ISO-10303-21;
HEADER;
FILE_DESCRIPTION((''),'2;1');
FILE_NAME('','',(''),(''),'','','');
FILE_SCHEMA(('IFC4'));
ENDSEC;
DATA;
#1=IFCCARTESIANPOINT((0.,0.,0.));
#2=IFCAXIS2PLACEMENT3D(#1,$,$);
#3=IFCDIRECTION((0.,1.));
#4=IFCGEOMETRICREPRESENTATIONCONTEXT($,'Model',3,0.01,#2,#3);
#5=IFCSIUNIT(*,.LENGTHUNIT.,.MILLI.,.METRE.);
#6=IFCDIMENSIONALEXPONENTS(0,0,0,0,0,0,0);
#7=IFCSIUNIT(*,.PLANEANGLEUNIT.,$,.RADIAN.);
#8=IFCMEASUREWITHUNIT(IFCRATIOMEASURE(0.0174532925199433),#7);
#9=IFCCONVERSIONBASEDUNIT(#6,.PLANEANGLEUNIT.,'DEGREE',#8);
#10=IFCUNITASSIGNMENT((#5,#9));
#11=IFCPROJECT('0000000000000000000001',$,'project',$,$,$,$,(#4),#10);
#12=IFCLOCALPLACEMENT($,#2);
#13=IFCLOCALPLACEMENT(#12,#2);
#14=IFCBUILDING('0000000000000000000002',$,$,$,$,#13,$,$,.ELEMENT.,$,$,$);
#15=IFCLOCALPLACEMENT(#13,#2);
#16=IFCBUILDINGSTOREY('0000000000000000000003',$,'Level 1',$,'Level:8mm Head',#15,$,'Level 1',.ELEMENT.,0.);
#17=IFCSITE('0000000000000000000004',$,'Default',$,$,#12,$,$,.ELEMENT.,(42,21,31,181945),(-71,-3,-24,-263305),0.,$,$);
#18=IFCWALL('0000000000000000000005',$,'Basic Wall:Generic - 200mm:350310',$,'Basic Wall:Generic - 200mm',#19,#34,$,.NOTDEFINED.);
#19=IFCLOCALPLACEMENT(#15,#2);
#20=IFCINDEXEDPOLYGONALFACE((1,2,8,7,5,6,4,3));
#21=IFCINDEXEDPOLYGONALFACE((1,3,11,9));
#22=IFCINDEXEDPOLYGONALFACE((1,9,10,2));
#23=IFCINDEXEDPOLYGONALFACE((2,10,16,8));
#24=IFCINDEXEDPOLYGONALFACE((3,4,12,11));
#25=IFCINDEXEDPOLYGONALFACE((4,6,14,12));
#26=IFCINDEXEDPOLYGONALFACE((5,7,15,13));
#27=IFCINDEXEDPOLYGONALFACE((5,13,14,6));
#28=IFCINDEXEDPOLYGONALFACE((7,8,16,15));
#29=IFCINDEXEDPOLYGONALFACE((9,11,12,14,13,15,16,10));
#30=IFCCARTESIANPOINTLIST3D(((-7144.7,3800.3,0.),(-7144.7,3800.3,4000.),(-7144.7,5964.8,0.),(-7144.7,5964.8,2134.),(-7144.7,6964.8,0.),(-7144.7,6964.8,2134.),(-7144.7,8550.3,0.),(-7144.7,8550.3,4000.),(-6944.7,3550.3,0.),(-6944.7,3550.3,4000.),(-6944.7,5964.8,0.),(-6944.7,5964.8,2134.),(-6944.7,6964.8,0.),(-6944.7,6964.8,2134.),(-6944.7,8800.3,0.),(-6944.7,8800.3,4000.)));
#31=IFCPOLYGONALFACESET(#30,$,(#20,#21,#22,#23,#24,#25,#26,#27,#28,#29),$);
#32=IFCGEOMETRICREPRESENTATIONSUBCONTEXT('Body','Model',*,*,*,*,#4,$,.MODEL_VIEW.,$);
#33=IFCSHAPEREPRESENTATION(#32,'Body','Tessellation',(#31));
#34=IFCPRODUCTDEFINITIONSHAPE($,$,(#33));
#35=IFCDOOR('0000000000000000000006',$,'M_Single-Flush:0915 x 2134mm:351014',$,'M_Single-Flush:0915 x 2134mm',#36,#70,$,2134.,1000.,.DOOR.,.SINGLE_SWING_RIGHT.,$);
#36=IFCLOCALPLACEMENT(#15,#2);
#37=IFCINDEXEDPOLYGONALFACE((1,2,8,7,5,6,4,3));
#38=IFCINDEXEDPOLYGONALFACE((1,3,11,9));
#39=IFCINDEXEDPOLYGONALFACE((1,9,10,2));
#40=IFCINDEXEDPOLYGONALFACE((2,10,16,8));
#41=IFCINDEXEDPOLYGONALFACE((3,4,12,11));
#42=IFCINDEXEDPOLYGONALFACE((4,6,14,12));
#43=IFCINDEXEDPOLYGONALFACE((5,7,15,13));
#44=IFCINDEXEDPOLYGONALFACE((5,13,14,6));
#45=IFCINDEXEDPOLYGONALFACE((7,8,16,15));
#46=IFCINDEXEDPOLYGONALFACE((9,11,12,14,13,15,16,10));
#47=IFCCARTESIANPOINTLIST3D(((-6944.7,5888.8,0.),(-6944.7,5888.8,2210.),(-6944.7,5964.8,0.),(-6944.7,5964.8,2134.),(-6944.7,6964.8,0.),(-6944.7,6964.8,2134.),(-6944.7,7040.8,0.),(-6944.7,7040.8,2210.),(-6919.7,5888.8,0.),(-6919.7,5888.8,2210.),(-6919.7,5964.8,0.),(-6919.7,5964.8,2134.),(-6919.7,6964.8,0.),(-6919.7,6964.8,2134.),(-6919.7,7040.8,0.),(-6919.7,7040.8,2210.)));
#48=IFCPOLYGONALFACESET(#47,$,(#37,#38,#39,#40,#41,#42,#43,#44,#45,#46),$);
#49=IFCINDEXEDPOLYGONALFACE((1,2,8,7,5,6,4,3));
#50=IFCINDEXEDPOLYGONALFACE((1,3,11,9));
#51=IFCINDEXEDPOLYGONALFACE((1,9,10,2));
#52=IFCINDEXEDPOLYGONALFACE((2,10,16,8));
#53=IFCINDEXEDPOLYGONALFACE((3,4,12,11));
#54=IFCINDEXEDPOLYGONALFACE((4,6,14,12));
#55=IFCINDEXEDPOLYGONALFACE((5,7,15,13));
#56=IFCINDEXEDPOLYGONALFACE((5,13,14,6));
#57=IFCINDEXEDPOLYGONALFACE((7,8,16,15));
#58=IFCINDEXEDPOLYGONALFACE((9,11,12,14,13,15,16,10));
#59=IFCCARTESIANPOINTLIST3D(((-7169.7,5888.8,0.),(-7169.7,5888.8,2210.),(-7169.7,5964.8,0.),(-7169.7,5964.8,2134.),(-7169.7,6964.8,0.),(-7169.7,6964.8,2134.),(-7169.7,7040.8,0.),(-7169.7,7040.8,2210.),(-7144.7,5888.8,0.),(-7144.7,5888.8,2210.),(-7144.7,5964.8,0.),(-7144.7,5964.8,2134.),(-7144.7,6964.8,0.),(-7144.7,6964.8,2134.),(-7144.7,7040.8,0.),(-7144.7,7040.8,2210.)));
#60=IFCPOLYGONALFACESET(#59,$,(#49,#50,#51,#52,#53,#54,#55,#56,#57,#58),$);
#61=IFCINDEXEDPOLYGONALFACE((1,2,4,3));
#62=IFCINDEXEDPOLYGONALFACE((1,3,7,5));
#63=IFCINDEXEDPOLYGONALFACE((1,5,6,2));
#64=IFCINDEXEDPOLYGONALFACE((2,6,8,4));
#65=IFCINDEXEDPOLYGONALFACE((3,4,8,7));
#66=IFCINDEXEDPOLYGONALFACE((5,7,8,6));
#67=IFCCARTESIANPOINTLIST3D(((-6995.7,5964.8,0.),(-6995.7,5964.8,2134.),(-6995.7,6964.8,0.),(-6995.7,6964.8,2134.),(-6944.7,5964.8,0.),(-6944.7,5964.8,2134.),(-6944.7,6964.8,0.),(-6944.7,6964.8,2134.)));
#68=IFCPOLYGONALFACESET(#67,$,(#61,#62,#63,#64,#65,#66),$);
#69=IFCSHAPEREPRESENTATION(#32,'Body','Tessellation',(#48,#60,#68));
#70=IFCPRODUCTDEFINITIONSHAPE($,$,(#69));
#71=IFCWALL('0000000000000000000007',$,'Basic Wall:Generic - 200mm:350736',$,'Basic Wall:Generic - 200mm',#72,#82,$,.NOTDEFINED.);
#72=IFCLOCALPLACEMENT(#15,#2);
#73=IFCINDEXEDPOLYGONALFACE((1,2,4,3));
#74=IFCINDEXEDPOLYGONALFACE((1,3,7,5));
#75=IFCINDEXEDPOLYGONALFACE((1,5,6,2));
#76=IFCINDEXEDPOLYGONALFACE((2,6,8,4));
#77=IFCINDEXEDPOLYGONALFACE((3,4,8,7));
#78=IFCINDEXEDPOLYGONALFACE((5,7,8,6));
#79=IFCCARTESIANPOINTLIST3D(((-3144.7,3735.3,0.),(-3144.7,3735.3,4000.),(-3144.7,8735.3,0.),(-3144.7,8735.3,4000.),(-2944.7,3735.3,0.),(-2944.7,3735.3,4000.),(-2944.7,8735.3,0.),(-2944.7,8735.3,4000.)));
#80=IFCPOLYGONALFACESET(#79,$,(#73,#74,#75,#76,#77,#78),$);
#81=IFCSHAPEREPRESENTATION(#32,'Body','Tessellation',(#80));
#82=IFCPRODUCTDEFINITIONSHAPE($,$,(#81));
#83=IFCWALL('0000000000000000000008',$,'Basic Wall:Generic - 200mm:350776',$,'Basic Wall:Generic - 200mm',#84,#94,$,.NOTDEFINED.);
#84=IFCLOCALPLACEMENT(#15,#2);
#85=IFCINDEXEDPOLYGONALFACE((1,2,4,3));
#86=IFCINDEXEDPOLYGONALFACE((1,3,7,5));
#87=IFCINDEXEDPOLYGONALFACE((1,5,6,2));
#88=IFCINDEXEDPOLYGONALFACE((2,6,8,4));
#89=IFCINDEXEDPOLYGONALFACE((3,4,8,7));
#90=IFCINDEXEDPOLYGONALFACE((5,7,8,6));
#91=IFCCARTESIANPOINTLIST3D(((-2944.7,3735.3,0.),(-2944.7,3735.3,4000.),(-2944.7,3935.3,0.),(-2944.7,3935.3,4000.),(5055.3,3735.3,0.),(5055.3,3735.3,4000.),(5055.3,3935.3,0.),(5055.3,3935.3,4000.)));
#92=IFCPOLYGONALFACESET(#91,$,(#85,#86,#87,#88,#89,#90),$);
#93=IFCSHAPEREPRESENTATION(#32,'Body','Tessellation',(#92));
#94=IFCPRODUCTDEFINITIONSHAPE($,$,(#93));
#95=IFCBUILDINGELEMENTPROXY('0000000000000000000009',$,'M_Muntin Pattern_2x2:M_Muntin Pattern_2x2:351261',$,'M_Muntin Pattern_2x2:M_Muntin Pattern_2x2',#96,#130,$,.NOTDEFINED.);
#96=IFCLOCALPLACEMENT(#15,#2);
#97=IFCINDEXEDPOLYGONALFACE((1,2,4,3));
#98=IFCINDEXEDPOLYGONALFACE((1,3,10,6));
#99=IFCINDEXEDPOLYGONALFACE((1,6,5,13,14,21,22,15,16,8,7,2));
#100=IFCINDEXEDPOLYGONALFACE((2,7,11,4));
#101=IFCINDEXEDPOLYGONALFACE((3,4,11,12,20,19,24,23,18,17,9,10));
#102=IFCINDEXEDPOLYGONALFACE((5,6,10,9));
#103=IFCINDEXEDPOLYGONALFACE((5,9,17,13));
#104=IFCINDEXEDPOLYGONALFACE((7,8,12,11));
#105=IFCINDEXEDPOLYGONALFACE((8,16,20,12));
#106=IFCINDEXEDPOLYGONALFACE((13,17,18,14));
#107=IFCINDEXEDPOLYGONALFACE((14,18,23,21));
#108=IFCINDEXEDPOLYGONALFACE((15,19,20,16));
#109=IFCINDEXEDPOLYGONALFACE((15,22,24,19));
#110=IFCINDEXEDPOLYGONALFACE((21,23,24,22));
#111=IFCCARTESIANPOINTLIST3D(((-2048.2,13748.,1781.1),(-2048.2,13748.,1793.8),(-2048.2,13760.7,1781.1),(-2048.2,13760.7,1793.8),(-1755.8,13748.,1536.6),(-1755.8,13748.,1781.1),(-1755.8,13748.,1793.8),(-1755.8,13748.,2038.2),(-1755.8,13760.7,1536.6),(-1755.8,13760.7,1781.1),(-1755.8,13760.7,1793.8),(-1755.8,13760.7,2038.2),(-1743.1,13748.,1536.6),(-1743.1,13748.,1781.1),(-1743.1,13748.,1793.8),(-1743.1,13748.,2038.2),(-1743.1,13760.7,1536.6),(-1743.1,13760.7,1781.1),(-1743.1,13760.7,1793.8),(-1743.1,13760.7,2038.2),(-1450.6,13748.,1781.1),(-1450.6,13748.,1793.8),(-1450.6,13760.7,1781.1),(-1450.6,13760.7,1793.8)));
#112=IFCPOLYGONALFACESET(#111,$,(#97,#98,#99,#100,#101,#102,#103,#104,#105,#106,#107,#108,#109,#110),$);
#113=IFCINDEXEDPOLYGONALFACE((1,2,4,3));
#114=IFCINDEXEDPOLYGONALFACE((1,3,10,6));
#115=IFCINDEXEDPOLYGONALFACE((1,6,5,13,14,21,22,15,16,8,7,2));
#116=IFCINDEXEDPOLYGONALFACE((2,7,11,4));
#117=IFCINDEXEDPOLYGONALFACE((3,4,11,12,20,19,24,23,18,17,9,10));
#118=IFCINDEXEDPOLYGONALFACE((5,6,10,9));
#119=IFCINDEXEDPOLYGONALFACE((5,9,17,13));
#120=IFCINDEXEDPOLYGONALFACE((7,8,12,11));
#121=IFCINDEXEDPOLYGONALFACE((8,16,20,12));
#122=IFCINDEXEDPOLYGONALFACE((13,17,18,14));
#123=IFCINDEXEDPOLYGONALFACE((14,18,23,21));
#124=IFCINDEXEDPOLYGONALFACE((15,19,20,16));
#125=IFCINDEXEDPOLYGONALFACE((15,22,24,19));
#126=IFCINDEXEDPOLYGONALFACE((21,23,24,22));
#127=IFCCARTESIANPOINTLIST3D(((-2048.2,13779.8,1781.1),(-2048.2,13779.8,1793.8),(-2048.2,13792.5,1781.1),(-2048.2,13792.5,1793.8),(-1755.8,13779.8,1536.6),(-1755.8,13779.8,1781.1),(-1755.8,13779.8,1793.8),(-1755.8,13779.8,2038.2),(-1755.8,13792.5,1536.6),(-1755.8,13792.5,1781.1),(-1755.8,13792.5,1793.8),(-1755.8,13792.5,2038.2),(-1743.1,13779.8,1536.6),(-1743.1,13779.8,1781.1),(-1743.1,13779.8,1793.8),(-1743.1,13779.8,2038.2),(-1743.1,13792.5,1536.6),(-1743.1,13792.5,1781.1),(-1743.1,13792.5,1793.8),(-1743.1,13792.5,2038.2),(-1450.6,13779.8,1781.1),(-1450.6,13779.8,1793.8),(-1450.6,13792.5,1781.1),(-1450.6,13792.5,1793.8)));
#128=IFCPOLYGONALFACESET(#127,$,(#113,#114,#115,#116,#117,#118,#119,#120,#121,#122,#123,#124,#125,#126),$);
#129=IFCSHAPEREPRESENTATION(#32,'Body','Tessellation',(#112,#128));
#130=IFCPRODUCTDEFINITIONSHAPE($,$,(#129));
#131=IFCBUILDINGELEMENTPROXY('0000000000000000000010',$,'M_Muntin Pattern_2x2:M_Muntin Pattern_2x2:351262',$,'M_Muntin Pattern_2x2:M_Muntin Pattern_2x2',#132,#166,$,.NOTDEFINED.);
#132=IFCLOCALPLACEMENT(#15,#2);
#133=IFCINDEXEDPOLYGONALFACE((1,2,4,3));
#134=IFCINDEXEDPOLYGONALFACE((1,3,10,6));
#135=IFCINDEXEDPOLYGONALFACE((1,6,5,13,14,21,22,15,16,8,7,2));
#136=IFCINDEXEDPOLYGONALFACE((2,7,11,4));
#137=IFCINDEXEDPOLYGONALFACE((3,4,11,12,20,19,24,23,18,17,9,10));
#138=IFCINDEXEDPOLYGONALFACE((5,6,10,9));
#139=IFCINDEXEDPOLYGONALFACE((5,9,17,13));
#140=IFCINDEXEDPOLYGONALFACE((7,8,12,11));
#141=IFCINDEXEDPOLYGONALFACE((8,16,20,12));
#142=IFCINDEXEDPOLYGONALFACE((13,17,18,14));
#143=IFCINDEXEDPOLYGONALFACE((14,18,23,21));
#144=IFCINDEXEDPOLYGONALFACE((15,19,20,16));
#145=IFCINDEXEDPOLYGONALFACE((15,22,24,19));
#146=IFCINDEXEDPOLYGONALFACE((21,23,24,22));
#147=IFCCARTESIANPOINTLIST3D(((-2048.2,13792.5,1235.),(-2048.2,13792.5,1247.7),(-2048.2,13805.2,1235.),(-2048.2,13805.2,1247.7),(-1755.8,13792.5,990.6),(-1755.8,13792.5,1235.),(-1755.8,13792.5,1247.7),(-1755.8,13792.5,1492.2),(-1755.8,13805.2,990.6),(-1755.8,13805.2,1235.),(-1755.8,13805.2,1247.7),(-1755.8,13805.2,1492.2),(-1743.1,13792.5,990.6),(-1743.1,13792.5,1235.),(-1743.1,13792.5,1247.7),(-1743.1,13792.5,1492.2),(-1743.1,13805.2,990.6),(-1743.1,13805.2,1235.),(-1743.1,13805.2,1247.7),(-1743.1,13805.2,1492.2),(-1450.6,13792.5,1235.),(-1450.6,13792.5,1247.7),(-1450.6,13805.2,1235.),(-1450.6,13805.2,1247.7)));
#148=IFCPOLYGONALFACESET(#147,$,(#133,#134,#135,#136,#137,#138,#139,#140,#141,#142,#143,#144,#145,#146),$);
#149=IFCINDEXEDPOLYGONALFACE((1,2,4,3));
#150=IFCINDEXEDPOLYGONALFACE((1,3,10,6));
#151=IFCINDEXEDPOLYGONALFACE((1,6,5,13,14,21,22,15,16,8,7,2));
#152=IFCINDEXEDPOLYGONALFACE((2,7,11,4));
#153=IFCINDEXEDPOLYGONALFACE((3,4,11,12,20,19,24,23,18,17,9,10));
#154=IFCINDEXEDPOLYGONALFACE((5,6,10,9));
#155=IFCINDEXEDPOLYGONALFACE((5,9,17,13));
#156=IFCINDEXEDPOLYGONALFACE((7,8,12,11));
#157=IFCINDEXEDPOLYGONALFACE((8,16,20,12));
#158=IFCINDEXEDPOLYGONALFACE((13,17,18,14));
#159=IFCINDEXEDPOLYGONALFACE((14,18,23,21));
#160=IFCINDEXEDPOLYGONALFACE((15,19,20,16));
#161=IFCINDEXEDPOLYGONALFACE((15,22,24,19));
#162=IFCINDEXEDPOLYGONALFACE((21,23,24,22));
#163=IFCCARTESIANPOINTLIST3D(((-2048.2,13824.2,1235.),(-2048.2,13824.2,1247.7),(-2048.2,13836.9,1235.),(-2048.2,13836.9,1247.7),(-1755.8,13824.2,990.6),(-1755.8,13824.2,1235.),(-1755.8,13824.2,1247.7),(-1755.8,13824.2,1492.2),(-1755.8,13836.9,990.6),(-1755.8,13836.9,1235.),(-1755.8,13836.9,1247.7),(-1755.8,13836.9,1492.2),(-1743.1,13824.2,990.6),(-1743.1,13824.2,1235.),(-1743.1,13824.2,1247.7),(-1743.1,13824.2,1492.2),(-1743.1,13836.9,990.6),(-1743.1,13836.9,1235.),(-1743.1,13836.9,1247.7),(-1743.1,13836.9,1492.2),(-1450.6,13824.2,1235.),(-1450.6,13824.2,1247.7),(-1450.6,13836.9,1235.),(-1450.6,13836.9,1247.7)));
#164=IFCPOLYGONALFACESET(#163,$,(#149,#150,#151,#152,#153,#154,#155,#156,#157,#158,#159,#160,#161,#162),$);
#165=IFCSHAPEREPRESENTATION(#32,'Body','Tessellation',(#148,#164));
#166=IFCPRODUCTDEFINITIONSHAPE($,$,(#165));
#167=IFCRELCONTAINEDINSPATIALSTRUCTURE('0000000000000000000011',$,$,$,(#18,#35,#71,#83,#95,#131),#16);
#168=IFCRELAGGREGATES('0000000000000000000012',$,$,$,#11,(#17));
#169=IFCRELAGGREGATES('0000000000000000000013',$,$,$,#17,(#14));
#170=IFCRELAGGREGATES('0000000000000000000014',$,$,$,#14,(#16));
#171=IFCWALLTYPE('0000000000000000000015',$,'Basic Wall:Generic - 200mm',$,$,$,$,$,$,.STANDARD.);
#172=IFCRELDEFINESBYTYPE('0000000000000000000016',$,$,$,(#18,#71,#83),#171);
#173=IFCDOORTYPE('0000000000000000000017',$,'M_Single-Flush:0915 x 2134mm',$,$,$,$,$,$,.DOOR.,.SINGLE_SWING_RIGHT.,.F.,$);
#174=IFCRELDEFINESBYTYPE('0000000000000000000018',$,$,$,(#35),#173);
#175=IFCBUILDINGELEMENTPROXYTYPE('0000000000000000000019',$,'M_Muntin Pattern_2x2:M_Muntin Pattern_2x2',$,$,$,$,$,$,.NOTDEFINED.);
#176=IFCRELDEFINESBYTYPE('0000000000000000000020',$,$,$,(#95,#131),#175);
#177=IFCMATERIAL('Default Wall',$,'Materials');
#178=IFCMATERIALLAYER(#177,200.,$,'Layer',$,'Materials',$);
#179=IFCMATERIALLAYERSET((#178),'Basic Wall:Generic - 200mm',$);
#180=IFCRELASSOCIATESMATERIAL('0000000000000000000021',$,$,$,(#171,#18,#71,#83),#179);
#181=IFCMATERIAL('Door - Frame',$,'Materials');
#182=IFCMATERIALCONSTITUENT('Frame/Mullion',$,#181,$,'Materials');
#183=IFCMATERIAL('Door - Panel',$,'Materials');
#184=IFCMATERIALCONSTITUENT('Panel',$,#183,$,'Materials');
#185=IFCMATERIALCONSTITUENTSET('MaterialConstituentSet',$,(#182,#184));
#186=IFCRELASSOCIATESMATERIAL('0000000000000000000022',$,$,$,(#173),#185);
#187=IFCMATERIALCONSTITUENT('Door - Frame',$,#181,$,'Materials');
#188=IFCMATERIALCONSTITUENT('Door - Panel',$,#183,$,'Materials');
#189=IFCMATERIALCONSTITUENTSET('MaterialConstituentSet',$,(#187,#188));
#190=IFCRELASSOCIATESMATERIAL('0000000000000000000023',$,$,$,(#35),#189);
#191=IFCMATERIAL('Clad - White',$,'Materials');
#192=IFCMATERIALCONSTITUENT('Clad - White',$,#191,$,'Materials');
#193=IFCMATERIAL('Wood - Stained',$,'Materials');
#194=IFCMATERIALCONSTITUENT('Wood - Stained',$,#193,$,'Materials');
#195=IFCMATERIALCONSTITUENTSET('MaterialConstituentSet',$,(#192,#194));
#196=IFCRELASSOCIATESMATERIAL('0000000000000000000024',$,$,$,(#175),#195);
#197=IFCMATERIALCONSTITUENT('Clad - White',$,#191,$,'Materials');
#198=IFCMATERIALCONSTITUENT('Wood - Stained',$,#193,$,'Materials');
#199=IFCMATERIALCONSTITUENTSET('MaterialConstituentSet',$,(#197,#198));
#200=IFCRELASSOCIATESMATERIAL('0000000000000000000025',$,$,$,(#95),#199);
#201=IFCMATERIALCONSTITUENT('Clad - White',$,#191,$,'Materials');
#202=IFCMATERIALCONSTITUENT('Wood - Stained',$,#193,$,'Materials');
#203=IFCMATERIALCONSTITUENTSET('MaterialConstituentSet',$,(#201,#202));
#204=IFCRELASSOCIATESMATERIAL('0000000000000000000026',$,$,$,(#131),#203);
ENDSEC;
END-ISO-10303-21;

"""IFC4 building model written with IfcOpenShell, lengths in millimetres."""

from ifc_helpers import new_model, entity, si_unit, converted_unit, direction, frame, frame_2d, origin, place, context, subcontext, project, spatial, polyline, rectangle, outline, extrude, source, transform, mapped, material, layer, layer_set, layer_usage, constituent, constituent_set, type_object, type_shapes, element, fill, save


model = new_model("IFC4")

# Units and contexts
model_context = context("Model", 3, precision=0.01, world=origin(), true_north=direction((0.0, 1.0)))
body_context = subcontext(model_context, "Body", "Model", "MODEL_VIEW")
ifc_project = project(units=[si_unit("LENGTHUNIT", "METRE", prefix="MILLI"), converted_unit("PLANEANGLEUNIT", "DEGREE", entity("IfcRatioMeasure", 0.0174532925199433), si_unit("PLANEANGLEUNIT", "RADIAN"), dimensions=[0, 0, 0, 0, 0, 0, 0])], contexts=[model_context])

# Site, building, storey
site_placement = place(None, origin())
site = spatial("IfcSite", under=ifc_project, at=site_placement, Name="Default", CompositionType="ELEMENT", RefLatitude=(42, 21, 31, 181945), RefLongitude=(-71, -3, -24, -263305), RefElevation=0.0)
building_placement = place(site_placement, origin())
building = spatial("IfcBuilding", under=site, at=building_placement, CompositionType="ELEMENT")
storey_placement = place(building_placement, origin())
storey = spatial("IfcBuildingStorey", under=building, at=storey_placement, Name="Level 1", ObjectType="Level:8mm Head", LongName="Level 1", CompositionType="ELEMENT", Elevation=0.0)

# Shared definitions
ifc_material_1 = material(Name="Default Wall", Category="Materials")
ifc_layer = layer(ifc_material_1, 200.0, Name="Layer", Category="Materials")
ifc_layer_set = layer_set([ifc_layer], Name="Basic Wall:Generic - 200mm")
wall_type = type_object("IfcWallType", Name="Basic Wall:Generic - 200mm", PredefinedType="STANDARD", material=ifc_layer_set)
ifc_material_2 = material(Name="Door - Frame", Category="Materials")
ifc_material_3 = material(Name="Door - Panel", Category="Materials")
ifc_constituent_1 = constituent(ifc_material_2, Name="Frame/Mullion", Category="Materials")
ifc_constituent_2 = constituent(ifc_material_3, Name="Panel", Category="Materials")
ifc_constituent_set_1 = constituent_set(constituents=[ifc_constituent_1, ifc_constituent_2], Name="MaterialConstituentSet")
door_type = type_object("IfcDoorType", Name="M_Single-Flush:0915 x 2134mm", OperationType="SINGLE_SWING_RIGHT", ParameterTakesPrecedence=False, PredefinedType="DOOR", material=ifc_constituent_set_1)
shared_shape_1 = source(origin(), body_context, "Body", "SweptSolid", [
    extrude(outline(polyline([(-576.0, -1124.0), (576.0, -1124.0), (576.0, 1086.0), (500.0, 1086.0), (500.0, -1048.0), (-500.0, -1048.0), (-500.0, 1086.0), (-576.0, 1086.0), (-576.0, -1124.0)])), frame((500.0, 200.0, 1086.0), z_axis=(0.0, 1.0, 0.0), x_axis=(1.0, 0.0, 0.0)), (0.0, 0.0, 1.0), 25.0),
    extrude(outline(polyline([(-1124.0, -576.0), (1086.0, -576.0), (1086.0, -500.0), (-1048.0, -500.0), (-1048.0, 500.0), (1086.0, 500.0), (1086.0, 576.0), (-1124.0, 576.0), (-1124.0, -576.0)])), frame((500.0, -25.0, 1086.0), z_axis=(0.0, 1.0, 0.0), x_axis=(0.0, 0.0, -1.0)), (0.0, 0.0, 1.0), 25.0),
    extrude(rectangle(XDim=51.0, YDim=1000.0, at=frame_2d((0.0, 0.0), x_axis=(1.0, 0.0))), frame((500.0, 174.5, 0.0), z_axis=(0.0, 0.0, 1.0), x_axis=(0.0, 1.0, 0.0)), (0.0, 0.0, 1.0), 2134.0),
])
type_shapes(door_type, [shared_shape_1])
ifc_material_4 = material(Name="Wood - Stained", Category="Materials")

# Wall, opening, door
ifc_layer_usage_1 = layer_usage(ifc_layer_set, "AXIS2", "NEGATIVE", 100.0)
wall_1_placement = place(storey_placement, frame((-7044.7, 8800.3, 0.0), z_axis=(0.0, 0.0, 1.0), x_axis=(0.0, -1.0, 0.0)))
wall_1 = element("IfcWall", 1, at=wall_1_placement, inside=storey, type_object=wall_type, material=ifc_layer_usage_1, Name="Basic Wall:Generic - 200mm:350310", ObjectType="Basic Wall:Generic - 200mm", PredefinedType="NOTDEFINED", context=body_context, shape_type="SweptSolid", body=[
    extrude(outline(polyline([(250.0, -100.0), (5000.0, -100.0), (5250.0, 100.0), (4929.8, 100.0), (0.0, 100.0), (250.0, -100.0)])), origin(), (0.0, 0.0, 1.0), 4000.0),
])
opening_1_placement = place(wall_1_placement, frame((1835.4, -100.0, 0.0)))
opening_1 = element("IfcOpeningElement", 2, at=opening_1_placement, cuts=wall_1, PredefinedType="OPENING", context=body_context, shape_type="SweptSolid", body=[
    extrude(rectangle(XDim=1000.0, YDim=2134.0, at=frame_2d((1067.0, 500.0), x_axis=(0.0, 1.0))), frame((0.0, 0.0, 0.0), z_axis=(0.0, 1.0, 0.0), x_axis=(0.0, 0.0, 1.0)), (0.0, 0.0, 1.0), 200.0),
])
ifc_constituent_3 = constituent(ifc_material_2, Name="Door - Frame", Category="Materials")
ifc_constituent_4 = constituent(ifc_material_3, Name="Door - Panel", Category="Materials")
ifc_constituent_set_2 = constituent_set(constituents=[ifc_constituent_3, ifc_constituent_4], Name="MaterialConstituentSet")
door_1_placement = place(opening_1_placement, origin())
door_1 = element("IfcDoor", 3, at=door_1_placement, inside=storey, type_object=door_type, material=ifc_constituent_set_2, Name="M_Single-Flush:0915 x 2134mm:351014", ObjectType="M_Single-Flush:0915 x 2134mm", OperationType="SINGLE_SWING_RIGHT", OverallHeight=2134.0, OverallWidth=1000.0, PredefinedType="DOOR", context=body_context, shape_type="MappedRepresentation", body=[
    mapped(shared_shape_1, transform((0.0, 0.0, 0.0), scale=1.0)),
])
fill(opening_1, door_1)

# Walls
ifc_layer_usage_2 = layer_usage(ifc_layer_set, "AXIS2", "NEGATIVE", 100.0)
wall_2_placement = place(storey_placement, frame((-3044.7, 8735.3, 0.0), z_axis=(0.0, 0.0, 1.0), x_axis=(0.0, -1.0, 0.0)))
element("IfcWall", 4, at=wall_2_placement, inside=storey, type_object=wall_type, material=ifc_layer_usage_2, Name="Basic Wall:Generic - 200mm:350736", ObjectType="Basic Wall:Generic - 200mm", PredefinedType="NOTDEFINED", context=body_context, shape_type="SweptSolid", body=[
    extrude(rectangle(XDim=5000.0, YDim=200.0, at=frame_2d((2500.0, 0.0), x_axis=(-1.0, 0.0))), origin(), (0.0, 0.0, 1.0), 4000.0),
])
ifc_layer_usage_3 = layer_usage(ifc_layer_set, "AXIS2", "NEGATIVE", 100.0)
wall_3_placement = place(storey_placement, frame((-2944.7, 3835.3, 0.0)))
element("IfcWall", 5, at=wall_3_placement, inside=storey, type_object=wall_type, material=ifc_layer_usage_3, Name="Basic Wall:Generic - 200mm:350776", ObjectType="Basic Wall:Generic - 200mm", PredefinedType="NOTDEFINED", context=body_context, shape_type="SweptSolid", body=[
    extrude(rectangle(XDim=8000.0, YDim=200.0, at=frame_2d((4000.0, 0.0), x_axis=(-1.0, 0.0))), origin(), (0.0, 0.0, 1.0), 4000.0),
])

# Building element proxies
ifc_material_5 = material(Name="Clad - White", Category="Materials")
ifc_constituent_5 = constituent(ifc_material_5, Name="Clad - White", Category="Materials")
ifc_constituent_6 = constituent(ifc_material_4, Name="Wood - Stained", Category="Materials")
ifc_constituent_set_3 = constituent_set(constituents=[ifc_constituent_5, ifc_constituent_6], Name="MaterialConstituentSet")
ifc_constituent_7 = constituent(ifc_material_5, Name="Clad - White", Category="Materials")
ifc_constituent_8 = constituent(ifc_material_4, Name="Wood - Stained", Category="Materials")
ifc_constituent_set_4 = constituent_set(constituents=[ifc_constituent_7, ifc_constituent_8], Name="MaterialConstituentSet")
building_element_proxy_type_1 = type_object("IfcBuildingElementProxyType", Name="M_Muntin Pattern_2x2:M_Muntin Pattern_2x2", PredefinedType="NOTDEFINED", material=ifc_constituent_set_4)
shared_shape_2 = source(origin(), body_context, "Body", "SweptSolid", [
    extrude(outline(polyline([(6.4, -6.4), (250.8, -6.4), (250.8, 6.3), (6.4, 6.3), (6.4, 298.8), (-6.3, 298.8), (-6.3, 6.3), (-250.8, 6.3), (-250.8, -6.4), (-6.3, -6.4), (-6.3, -298.8), (6.4, -298.8), (6.4, -6.4)])), frame((0.0, 9.5, 250.8), z_axis=(0.0, 1.0, 0.0), x_axis=(0.0, 0.0, 1.0)), (0.0, 0.0, 1.0), 12.7),
    extrude(outline(polyline([(6.4, -6.4), (250.8, -6.4), (250.8, 6.3), (6.4, 6.3), (6.4, 298.8), (-6.3, 298.8), (-6.3, 6.3), (-250.8, 6.3), (-250.8, -6.4), (-6.3, -6.4), (-6.3, -298.8), (6.4, -298.8), (6.4, -6.4)])), frame((0.0, -22.2, 250.8), z_axis=(0.0, 1.0, 0.0), x_axis=(0.0, 0.0, 1.0)), (0.0, 0.0, 1.0), 12.7),
])
type_shapes(building_element_proxy_type_1, [shared_shape_2])
proxy_1_placement = place(storey_placement, frame((-1749.4, 13770.3, 1536.6), z_axis=(0.0, 0.0, 1.0), x_axis=(-1.0, 0.0, 0.0)))
element("IfcBuildingElementProxy", 6, at=proxy_1_placement, inside=storey, type_object=building_element_proxy_type_1, material=ifc_constituent_set_3, Name="M_Muntin Pattern_2x2:M_Muntin Pattern_2x2:351261", ObjectType="M_Muntin Pattern_2x2:M_Muntin Pattern_2x2", PredefinedType="NOTDEFINED", context=body_context, shape_type="MappedRepresentation", body=[
    mapped(shared_shape_2, transform((0.0, 0.0, 0.0), scale=1.0)),
])
ifc_constituent_9 = constituent(ifc_material_5, Name="Clad - White", Category="Materials")
ifc_constituent_10 = constituent(ifc_material_4, Name="Wood - Stained", Category="Materials")
ifc_constituent_set_5 = constituent_set(constituents=[ifc_constituent_9, ifc_constituent_10], Name="MaterialConstituentSet")
proxy_2_placement = place(storey_placement, frame((-1749.4, 13814.7, 990.6), z_axis=(0.0, 0.0, 1.0), x_axis=(-1.0, 0.0, 0.0)))
element("IfcBuildingElementProxy", 7, at=proxy_2_placement, inside=storey, type_object=building_element_proxy_type_1, material=ifc_constituent_set_5, Name="M_Muntin Pattern_2x2:M_Muntin Pattern_2x2:351262", ObjectType="M_Muntin Pattern_2x2:M_Muntin Pattern_2x2", PredefinedType="NOTDEFINED", context=body_context, shape_type="MappedRepresentation", body=[
    mapped(shared_shape_2, transform((0.0, 0.0, 0.0), scale=1.0)),
])

save(model, "model.ifc")
